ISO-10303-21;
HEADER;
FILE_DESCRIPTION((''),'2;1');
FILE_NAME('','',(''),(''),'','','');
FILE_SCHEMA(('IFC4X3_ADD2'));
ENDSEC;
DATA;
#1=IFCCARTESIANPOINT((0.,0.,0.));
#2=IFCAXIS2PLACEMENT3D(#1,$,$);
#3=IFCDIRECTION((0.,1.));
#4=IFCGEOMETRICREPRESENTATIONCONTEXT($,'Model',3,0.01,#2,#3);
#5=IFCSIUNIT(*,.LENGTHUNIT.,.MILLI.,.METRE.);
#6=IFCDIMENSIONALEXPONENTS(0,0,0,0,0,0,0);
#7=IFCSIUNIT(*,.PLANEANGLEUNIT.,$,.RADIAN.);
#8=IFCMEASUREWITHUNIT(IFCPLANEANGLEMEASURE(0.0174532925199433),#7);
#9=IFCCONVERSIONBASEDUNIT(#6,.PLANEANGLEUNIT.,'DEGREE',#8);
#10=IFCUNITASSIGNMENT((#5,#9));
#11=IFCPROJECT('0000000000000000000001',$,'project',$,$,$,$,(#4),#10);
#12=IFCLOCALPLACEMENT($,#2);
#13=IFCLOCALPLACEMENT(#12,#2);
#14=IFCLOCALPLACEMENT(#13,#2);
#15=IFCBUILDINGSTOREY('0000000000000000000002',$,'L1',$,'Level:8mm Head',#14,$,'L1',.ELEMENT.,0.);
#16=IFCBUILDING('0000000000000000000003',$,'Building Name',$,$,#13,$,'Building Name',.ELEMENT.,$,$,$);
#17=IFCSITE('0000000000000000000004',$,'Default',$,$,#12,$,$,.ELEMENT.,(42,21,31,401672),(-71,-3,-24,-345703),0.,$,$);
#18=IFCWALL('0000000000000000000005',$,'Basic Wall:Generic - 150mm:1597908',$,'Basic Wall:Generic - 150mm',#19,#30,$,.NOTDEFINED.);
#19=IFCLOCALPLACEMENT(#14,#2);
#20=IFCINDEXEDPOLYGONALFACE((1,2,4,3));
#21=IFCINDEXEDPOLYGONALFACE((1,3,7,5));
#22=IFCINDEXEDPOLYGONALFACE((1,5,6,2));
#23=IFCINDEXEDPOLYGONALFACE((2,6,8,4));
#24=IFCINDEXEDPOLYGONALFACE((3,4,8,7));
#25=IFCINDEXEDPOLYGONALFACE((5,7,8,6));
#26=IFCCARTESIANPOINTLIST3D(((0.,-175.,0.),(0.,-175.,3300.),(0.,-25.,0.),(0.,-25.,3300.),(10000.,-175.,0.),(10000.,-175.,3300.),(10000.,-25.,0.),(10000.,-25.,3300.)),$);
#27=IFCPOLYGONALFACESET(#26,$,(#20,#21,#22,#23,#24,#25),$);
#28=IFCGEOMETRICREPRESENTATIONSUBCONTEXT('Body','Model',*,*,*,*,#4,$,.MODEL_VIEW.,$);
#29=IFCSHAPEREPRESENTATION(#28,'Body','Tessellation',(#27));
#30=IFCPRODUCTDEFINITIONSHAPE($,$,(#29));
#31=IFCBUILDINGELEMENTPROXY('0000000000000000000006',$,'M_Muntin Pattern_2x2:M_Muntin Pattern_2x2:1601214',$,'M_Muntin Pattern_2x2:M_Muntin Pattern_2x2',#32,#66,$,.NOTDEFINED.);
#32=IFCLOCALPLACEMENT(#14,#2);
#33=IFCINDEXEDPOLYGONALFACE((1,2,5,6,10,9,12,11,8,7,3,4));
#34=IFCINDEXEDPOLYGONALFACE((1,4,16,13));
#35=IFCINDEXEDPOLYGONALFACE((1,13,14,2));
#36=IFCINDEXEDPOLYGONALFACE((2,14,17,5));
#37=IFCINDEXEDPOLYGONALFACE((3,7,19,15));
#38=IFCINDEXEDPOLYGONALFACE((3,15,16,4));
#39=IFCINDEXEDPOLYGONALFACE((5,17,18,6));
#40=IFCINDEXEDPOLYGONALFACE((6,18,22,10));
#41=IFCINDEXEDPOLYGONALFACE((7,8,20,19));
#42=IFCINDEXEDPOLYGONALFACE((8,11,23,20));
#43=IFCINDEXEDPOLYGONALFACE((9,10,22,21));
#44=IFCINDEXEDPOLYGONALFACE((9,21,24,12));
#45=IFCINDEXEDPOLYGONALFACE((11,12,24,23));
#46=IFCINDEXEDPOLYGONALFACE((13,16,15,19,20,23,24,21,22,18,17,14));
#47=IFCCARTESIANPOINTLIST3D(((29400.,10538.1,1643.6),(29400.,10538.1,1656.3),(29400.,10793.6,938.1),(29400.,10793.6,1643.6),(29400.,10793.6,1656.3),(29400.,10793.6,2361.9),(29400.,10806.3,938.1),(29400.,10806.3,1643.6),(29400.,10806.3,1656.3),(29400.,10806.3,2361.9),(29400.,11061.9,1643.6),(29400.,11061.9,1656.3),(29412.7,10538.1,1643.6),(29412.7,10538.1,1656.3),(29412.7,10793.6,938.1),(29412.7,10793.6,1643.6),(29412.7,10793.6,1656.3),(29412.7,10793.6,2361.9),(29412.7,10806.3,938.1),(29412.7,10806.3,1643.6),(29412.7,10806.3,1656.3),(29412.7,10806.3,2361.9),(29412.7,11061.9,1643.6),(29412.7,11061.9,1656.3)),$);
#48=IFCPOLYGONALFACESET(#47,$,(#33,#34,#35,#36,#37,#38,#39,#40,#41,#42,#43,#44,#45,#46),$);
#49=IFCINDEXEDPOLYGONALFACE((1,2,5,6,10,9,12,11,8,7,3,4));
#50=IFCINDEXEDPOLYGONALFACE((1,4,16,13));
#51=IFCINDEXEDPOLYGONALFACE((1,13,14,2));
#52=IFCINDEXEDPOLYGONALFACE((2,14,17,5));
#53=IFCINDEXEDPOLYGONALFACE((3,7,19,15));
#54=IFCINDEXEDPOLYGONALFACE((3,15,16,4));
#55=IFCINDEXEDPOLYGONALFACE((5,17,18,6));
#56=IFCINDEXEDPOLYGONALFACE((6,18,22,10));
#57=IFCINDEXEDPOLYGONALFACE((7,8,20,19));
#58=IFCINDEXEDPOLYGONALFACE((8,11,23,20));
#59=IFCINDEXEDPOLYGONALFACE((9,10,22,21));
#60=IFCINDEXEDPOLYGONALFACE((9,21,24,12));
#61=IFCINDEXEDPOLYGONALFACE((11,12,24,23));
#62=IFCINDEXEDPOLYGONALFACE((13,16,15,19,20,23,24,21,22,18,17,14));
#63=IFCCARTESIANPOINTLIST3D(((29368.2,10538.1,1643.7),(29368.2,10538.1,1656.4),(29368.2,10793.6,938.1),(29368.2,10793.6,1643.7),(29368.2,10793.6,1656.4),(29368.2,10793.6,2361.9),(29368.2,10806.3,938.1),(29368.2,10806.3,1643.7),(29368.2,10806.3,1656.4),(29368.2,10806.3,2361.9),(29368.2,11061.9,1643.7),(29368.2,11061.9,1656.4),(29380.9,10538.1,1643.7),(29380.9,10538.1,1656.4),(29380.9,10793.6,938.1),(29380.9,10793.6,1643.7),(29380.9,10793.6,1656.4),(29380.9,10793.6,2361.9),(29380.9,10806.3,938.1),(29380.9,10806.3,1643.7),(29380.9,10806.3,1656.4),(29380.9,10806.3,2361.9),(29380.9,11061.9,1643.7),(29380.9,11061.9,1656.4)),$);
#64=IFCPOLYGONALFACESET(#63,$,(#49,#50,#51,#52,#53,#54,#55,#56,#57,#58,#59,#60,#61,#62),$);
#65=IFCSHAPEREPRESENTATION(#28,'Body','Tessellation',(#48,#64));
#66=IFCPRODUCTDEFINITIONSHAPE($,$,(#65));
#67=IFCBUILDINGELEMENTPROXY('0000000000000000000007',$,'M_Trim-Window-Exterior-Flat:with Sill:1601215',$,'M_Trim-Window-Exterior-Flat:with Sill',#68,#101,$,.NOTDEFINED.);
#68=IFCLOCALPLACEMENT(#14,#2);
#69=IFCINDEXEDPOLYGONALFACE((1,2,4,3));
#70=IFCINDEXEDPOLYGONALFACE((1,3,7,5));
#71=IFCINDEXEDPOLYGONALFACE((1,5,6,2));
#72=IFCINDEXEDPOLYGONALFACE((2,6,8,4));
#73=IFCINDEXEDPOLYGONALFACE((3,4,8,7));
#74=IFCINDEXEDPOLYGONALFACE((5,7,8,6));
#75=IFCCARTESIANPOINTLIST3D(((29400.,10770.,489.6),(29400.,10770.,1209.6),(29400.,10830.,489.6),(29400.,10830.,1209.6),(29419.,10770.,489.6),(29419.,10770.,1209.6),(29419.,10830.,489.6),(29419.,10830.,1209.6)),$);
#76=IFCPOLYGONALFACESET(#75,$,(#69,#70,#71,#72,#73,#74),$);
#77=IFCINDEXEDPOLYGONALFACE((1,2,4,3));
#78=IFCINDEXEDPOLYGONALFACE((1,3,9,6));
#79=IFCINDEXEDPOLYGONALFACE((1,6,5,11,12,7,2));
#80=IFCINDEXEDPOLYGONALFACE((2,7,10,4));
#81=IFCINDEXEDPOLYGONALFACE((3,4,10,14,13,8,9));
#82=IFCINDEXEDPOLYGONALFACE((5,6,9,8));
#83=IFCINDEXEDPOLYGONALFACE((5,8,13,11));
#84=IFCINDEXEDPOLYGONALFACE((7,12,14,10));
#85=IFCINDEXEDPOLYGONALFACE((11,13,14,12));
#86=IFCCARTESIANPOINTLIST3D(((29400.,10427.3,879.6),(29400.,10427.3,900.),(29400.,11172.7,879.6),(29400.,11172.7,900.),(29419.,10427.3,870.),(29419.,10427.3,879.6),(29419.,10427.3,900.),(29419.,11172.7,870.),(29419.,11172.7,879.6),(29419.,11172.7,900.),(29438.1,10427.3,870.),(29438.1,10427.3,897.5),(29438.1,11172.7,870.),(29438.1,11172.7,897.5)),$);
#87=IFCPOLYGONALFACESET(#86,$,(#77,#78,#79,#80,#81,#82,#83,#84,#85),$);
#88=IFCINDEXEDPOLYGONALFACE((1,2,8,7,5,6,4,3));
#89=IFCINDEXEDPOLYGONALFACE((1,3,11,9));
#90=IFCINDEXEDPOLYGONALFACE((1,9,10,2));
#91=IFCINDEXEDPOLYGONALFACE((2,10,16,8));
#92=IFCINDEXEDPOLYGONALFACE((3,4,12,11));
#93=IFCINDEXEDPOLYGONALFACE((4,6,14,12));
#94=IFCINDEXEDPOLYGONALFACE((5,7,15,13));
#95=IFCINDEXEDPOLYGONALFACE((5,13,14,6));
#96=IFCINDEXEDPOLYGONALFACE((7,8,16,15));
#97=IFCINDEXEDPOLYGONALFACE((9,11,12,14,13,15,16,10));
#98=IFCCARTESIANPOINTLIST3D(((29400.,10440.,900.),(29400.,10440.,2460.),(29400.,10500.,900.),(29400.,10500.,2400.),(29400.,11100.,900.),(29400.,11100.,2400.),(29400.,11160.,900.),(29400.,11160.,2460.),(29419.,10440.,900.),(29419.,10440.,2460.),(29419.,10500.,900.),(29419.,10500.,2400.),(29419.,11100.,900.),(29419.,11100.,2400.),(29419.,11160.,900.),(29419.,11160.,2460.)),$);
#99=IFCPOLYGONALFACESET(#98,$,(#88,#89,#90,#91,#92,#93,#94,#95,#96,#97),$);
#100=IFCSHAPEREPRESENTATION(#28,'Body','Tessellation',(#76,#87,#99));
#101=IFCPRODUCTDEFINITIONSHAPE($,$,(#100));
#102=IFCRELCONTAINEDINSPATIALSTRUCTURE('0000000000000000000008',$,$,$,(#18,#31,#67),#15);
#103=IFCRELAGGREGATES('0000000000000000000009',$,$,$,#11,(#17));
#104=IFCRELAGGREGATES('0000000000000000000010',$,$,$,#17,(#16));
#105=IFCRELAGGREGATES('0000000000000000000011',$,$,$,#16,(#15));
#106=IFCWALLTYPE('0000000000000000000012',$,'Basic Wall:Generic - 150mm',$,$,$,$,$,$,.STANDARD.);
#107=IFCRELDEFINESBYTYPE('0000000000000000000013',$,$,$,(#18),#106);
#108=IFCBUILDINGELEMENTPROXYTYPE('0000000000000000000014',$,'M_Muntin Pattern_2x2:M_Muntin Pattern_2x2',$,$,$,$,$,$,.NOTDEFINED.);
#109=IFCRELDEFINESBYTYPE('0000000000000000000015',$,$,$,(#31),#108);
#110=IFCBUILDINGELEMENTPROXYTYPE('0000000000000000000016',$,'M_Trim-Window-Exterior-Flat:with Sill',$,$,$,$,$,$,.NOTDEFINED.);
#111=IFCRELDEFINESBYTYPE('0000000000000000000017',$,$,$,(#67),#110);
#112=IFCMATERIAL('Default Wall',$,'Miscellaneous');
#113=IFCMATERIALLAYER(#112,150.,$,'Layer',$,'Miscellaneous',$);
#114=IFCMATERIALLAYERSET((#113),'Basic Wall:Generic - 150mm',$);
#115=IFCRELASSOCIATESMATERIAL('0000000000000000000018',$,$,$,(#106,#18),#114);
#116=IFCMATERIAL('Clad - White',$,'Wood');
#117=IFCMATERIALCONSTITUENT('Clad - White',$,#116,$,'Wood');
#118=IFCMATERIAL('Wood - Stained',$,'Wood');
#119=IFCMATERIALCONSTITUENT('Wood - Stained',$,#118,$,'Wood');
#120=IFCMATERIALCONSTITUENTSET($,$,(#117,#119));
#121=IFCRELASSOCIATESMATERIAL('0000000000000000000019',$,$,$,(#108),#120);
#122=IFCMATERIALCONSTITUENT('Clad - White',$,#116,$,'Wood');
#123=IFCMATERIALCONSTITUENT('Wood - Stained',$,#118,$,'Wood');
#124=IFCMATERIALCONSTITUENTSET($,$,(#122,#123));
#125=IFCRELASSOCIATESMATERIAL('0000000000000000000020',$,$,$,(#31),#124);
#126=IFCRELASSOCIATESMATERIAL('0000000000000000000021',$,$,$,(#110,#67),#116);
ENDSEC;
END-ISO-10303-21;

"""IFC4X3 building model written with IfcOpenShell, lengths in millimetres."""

from ifc_helpers import new_model, entity, si_unit, converted_unit, direction, frame, frame_2d, origin, place, context, subcontext, project, spatial, polyline, rectangle, outline, extrude, source, transform, mapped, material, layer, layer_set, constituent, constituent_set, type_object, type_shapes, element, save


model = new_model("IFC4X3")

# Units and contexts
model_context = context("Model", 3, precision=0.01, world=origin(), true_north=direction((0.0, 1.0)))
body_context = subcontext(model_context, "Body", "Model", "MODEL_VIEW")
ifc_project = project(units=[si_unit("LENGTHUNIT", "METRE", prefix="MILLI"), converted_unit("PLANEANGLEUNIT", "DEGREE", entity("IfcPlaneAngleMeasure", 0.0174532925199433), si_unit("PLANEANGLEUNIT", "RADIAN"), dimensions=[0, 0, 0, 0, 0, 0, 0])], contexts=[model_context])

# Site, building, storey
site_placement = place(None, origin())
site = spatial("IfcSite", under=ifc_project, at=site_placement, Name="Default", CompositionType="ELEMENT", RefLatitude=(42, 21, 31, 401672), RefLongitude=(-71, -3, -24, -345703), RefElevation=0.0)
building_placement = place(site_placement, origin())
building = spatial("IfcBuilding", under=site, at=building_placement, Name="Building Name", LongName="Building Name", CompositionType="ELEMENT")
storey_placement = place(building_placement, origin())
storey = spatial("IfcBuildingStorey", under=building, at=storey_placement, Name="L1", ObjectType="Level:8mm Head", LongName="L1", CompositionType="ELEMENT", Elevation=0.0)

# Shared definitions
ifc_material_1 = material(Name="Default Wall", Category="Miscellaneous")

# Wall
ifc_layer_1 = layer(ifc_material_1, 150.0, Name="Layer", Category="Miscellaneous")
ifc_layer_set_1 = layer_set([ifc_layer_1], Name="Basic Wall:Generic - 150mm")
wall_type_1 = type_object("IfcWallType", Name="Basic Wall:Generic - 150mm", PredefinedType="STANDARD", material=ifc_layer_set_1)
wall_1_placement = place(storey_placement, frame((0.0, -100.0, 0.0)))
element("IfcWall", 1, at=wall_1_placement, inside=storey, type_object=wall_type_1, material=ifc_layer_set_1, Name="Basic Wall:Generic - 150mm:1597908", ObjectType="Basic Wall:Generic - 150mm", PredefinedType="NOTDEFINED", context=body_context, shape_type="SweptSolid", body=[
    extrude(rectangle(XDim=10000.0, YDim=150.0, at=frame_2d((5000.0, 0.0), x_axis=(-1.0, 0.0))), origin(), (0.0, 0.0, 1.0), 3300.0),
])

# Building element proxies
ifc_material_2 = material(Name="Clad - White", Category="Wood")
ifc_constituent_1 = constituent(ifc_material_2, Name="Clad - White", Category="Wood")
ifc_material_3 = material(Name="Wood - Stained", Category="Wood")
ifc_constituent_2 = constituent(ifc_material_3, Name="Wood - Stained", Category="Wood")
ifc_constituent_set_1 = constituent_set(constituents=[ifc_constituent_1, ifc_constituent_2])
ifc_constituent_3 = constituent(ifc_material_2, Name="Clad - White", Category="Wood")
ifc_constituent_4 = constituent(ifc_material_3, Name="Wood - Stained", Category="Wood")
ifc_constituent_set_2 = constituent_set(constituents=[ifc_constituent_3, ifc_constituent_4])
building_element_proxy_type_1 = type_object("IfcBuildingElementProxyType", Name="M_Muntin Pattern_2x2:M_Muntin Pattern_2x2", PredefinedType="NOTDEFINED", material=ifc_constituent_set_2)
shared_shape_1 = source(origin(), body_context, "Body", "SweptSolid", [
    extrude(outline(polyline([(6.4, -6.4), (711.9, -6.4), (711.9, 6.3), (6.4, 6.3), (6.4, 261.9), (-6.3, 261.9), (-6.3, 6.3), (-711.9, 6.3), (-711.9, -6.4), (-6.3, -6.4), (-6.3, -261.9), (6.4, -261.9), (6.4, -6.4)])), frame((0.0, -22.2, 711.9), z_axis=(0.0, 1.0, 0.0), x_axis=(0.0, 0.0, 1.0)), (0.0, 0.0, 1.0), 12.7),
    extrude(outline(polyline([(6.4, -6.4), (711.9, -6.4), (711.9, 6.3), (6.4, 6.3), (6.4, 261.9), (-6.3, 261.9), (-6.3, 6.3), (-711.9, 6.3), (-711.9, -6.4), (-6.3, -6.4), (-6.3, -261.9), (6.4, -261.9), (6.4, -6.4)])), frame((0.0, 9.5, 711.9), z_axis=(0.0, 1.0, 0.0), x_axis=(0.0, 0.0, 1.0)), (0.0, 0.0, 1.0), 12.7),
])
type_shapes(building_element_proxy_type_1, [shared_shape_1])
proxy_1_placement = place(storey_placement, frame((29390.5, 10800.0, 938.1), z_axis=(0.0, 0.0, 1.0), x_axis=(0.0, 1.0, 0.0)))
element("IfcBuildingElementProxy", 2, at=proxy_1_placement, inside=storey, type_object=building_element_proxy_type_1, material=ifc_constituent_set_1, Name="M_Muntin Pattern_2x2:M_Muntin Pattern_2x2:1601214", ObjectType="M_Muntin Pattern_2x2:M_Muntin Pattern_2x2", PredefinedType="NOTDEFINED", context=body_context, shape_type="MappedRepresentation", body=[
    mapped(shared_shape_1, transform((0.0, 0.0, 0.0), scale=1.0)),
])
building_element_proxy_type_2 = type_object("IfcBuildingElementProxyType", Name="M_Trim-Window-Exterior-Flat:with Sill", PredefinedType="NOTDEFINED", material=ifc_material_2)
shared_shape_2 = source(origin(), body_context, "Body", "SweptSolid", [
    extrude(rectangle(XDim=720.0, YDim=60.0, at=frame_2d((0.0, 0.0), x_axis=(1.0, 0.0))), frame((0.0, -1550.4, 0.0), z_axis=(0.0, 0.0, 1.0), x_axis=(0.0, -1.0, 0.0)), (0.0, 0.0, 1.0), 19.1),
    extrude(outline(polyline([(-19.0, -15.2), (0.0, -15.2), (0.0, -5.7), (19.0, -5.7), (19.0, 14.8), (0.0, 14.8), (-19.0, 12.3), (-19.0, -15.2)])), frame((-372.7, -1514.8, 19.0), z_axis=(1.0, 0.0, 0.0), x_axis=(0.0, 0.0, -1.0)), (0.0, 0.0, 1.0), 745.4),
    extrude(outline(polyline([(-795.0, -360.0), (765.0, -360.0), (765.0, -300.0), (-735.0, -300.0), (-735.0, 300.0), (765.0, 300.0), (765.0, 360.0), (-795.0, 360.0), (-795.0, -360.0)])), frame((0.0, -735.0, 0.0), z_axis=(0.0, 0.0, 1.0), x_axis=(0.0, -1.0, 0.0)), (0.0, 0.0, 1.0), 19.1),
])
type_shapes(building_element_proxy_type_2, [shared_shape_2])
proxy_2_placement = place(storey_placement, frame((29400.0, 10800.0, 2400.0), z_axis=(1.0, 0.0, 0.0), x_axis=(0.0, 1.0, 0.0)))
element("IfcBuildingElementProxy", 3, at=proxy_2_placement, inside=storey, type_object=building_element_proxy_type_2, material=ifc_material_2, Name="M_Trim-Window-Exterior-Flat:with Sill:1601215", ObjectType="M_Trim-Window-Exterior-Flat:with Sill", PredefinedType="NOTDEFINED", context=body_context, shape_type="MappedRepresentation", body=[
    mapped(shared_shape_2, transform((0.0, 0.0, 0.0), scale=1.0)),
])

save(model, "model.ifc")
